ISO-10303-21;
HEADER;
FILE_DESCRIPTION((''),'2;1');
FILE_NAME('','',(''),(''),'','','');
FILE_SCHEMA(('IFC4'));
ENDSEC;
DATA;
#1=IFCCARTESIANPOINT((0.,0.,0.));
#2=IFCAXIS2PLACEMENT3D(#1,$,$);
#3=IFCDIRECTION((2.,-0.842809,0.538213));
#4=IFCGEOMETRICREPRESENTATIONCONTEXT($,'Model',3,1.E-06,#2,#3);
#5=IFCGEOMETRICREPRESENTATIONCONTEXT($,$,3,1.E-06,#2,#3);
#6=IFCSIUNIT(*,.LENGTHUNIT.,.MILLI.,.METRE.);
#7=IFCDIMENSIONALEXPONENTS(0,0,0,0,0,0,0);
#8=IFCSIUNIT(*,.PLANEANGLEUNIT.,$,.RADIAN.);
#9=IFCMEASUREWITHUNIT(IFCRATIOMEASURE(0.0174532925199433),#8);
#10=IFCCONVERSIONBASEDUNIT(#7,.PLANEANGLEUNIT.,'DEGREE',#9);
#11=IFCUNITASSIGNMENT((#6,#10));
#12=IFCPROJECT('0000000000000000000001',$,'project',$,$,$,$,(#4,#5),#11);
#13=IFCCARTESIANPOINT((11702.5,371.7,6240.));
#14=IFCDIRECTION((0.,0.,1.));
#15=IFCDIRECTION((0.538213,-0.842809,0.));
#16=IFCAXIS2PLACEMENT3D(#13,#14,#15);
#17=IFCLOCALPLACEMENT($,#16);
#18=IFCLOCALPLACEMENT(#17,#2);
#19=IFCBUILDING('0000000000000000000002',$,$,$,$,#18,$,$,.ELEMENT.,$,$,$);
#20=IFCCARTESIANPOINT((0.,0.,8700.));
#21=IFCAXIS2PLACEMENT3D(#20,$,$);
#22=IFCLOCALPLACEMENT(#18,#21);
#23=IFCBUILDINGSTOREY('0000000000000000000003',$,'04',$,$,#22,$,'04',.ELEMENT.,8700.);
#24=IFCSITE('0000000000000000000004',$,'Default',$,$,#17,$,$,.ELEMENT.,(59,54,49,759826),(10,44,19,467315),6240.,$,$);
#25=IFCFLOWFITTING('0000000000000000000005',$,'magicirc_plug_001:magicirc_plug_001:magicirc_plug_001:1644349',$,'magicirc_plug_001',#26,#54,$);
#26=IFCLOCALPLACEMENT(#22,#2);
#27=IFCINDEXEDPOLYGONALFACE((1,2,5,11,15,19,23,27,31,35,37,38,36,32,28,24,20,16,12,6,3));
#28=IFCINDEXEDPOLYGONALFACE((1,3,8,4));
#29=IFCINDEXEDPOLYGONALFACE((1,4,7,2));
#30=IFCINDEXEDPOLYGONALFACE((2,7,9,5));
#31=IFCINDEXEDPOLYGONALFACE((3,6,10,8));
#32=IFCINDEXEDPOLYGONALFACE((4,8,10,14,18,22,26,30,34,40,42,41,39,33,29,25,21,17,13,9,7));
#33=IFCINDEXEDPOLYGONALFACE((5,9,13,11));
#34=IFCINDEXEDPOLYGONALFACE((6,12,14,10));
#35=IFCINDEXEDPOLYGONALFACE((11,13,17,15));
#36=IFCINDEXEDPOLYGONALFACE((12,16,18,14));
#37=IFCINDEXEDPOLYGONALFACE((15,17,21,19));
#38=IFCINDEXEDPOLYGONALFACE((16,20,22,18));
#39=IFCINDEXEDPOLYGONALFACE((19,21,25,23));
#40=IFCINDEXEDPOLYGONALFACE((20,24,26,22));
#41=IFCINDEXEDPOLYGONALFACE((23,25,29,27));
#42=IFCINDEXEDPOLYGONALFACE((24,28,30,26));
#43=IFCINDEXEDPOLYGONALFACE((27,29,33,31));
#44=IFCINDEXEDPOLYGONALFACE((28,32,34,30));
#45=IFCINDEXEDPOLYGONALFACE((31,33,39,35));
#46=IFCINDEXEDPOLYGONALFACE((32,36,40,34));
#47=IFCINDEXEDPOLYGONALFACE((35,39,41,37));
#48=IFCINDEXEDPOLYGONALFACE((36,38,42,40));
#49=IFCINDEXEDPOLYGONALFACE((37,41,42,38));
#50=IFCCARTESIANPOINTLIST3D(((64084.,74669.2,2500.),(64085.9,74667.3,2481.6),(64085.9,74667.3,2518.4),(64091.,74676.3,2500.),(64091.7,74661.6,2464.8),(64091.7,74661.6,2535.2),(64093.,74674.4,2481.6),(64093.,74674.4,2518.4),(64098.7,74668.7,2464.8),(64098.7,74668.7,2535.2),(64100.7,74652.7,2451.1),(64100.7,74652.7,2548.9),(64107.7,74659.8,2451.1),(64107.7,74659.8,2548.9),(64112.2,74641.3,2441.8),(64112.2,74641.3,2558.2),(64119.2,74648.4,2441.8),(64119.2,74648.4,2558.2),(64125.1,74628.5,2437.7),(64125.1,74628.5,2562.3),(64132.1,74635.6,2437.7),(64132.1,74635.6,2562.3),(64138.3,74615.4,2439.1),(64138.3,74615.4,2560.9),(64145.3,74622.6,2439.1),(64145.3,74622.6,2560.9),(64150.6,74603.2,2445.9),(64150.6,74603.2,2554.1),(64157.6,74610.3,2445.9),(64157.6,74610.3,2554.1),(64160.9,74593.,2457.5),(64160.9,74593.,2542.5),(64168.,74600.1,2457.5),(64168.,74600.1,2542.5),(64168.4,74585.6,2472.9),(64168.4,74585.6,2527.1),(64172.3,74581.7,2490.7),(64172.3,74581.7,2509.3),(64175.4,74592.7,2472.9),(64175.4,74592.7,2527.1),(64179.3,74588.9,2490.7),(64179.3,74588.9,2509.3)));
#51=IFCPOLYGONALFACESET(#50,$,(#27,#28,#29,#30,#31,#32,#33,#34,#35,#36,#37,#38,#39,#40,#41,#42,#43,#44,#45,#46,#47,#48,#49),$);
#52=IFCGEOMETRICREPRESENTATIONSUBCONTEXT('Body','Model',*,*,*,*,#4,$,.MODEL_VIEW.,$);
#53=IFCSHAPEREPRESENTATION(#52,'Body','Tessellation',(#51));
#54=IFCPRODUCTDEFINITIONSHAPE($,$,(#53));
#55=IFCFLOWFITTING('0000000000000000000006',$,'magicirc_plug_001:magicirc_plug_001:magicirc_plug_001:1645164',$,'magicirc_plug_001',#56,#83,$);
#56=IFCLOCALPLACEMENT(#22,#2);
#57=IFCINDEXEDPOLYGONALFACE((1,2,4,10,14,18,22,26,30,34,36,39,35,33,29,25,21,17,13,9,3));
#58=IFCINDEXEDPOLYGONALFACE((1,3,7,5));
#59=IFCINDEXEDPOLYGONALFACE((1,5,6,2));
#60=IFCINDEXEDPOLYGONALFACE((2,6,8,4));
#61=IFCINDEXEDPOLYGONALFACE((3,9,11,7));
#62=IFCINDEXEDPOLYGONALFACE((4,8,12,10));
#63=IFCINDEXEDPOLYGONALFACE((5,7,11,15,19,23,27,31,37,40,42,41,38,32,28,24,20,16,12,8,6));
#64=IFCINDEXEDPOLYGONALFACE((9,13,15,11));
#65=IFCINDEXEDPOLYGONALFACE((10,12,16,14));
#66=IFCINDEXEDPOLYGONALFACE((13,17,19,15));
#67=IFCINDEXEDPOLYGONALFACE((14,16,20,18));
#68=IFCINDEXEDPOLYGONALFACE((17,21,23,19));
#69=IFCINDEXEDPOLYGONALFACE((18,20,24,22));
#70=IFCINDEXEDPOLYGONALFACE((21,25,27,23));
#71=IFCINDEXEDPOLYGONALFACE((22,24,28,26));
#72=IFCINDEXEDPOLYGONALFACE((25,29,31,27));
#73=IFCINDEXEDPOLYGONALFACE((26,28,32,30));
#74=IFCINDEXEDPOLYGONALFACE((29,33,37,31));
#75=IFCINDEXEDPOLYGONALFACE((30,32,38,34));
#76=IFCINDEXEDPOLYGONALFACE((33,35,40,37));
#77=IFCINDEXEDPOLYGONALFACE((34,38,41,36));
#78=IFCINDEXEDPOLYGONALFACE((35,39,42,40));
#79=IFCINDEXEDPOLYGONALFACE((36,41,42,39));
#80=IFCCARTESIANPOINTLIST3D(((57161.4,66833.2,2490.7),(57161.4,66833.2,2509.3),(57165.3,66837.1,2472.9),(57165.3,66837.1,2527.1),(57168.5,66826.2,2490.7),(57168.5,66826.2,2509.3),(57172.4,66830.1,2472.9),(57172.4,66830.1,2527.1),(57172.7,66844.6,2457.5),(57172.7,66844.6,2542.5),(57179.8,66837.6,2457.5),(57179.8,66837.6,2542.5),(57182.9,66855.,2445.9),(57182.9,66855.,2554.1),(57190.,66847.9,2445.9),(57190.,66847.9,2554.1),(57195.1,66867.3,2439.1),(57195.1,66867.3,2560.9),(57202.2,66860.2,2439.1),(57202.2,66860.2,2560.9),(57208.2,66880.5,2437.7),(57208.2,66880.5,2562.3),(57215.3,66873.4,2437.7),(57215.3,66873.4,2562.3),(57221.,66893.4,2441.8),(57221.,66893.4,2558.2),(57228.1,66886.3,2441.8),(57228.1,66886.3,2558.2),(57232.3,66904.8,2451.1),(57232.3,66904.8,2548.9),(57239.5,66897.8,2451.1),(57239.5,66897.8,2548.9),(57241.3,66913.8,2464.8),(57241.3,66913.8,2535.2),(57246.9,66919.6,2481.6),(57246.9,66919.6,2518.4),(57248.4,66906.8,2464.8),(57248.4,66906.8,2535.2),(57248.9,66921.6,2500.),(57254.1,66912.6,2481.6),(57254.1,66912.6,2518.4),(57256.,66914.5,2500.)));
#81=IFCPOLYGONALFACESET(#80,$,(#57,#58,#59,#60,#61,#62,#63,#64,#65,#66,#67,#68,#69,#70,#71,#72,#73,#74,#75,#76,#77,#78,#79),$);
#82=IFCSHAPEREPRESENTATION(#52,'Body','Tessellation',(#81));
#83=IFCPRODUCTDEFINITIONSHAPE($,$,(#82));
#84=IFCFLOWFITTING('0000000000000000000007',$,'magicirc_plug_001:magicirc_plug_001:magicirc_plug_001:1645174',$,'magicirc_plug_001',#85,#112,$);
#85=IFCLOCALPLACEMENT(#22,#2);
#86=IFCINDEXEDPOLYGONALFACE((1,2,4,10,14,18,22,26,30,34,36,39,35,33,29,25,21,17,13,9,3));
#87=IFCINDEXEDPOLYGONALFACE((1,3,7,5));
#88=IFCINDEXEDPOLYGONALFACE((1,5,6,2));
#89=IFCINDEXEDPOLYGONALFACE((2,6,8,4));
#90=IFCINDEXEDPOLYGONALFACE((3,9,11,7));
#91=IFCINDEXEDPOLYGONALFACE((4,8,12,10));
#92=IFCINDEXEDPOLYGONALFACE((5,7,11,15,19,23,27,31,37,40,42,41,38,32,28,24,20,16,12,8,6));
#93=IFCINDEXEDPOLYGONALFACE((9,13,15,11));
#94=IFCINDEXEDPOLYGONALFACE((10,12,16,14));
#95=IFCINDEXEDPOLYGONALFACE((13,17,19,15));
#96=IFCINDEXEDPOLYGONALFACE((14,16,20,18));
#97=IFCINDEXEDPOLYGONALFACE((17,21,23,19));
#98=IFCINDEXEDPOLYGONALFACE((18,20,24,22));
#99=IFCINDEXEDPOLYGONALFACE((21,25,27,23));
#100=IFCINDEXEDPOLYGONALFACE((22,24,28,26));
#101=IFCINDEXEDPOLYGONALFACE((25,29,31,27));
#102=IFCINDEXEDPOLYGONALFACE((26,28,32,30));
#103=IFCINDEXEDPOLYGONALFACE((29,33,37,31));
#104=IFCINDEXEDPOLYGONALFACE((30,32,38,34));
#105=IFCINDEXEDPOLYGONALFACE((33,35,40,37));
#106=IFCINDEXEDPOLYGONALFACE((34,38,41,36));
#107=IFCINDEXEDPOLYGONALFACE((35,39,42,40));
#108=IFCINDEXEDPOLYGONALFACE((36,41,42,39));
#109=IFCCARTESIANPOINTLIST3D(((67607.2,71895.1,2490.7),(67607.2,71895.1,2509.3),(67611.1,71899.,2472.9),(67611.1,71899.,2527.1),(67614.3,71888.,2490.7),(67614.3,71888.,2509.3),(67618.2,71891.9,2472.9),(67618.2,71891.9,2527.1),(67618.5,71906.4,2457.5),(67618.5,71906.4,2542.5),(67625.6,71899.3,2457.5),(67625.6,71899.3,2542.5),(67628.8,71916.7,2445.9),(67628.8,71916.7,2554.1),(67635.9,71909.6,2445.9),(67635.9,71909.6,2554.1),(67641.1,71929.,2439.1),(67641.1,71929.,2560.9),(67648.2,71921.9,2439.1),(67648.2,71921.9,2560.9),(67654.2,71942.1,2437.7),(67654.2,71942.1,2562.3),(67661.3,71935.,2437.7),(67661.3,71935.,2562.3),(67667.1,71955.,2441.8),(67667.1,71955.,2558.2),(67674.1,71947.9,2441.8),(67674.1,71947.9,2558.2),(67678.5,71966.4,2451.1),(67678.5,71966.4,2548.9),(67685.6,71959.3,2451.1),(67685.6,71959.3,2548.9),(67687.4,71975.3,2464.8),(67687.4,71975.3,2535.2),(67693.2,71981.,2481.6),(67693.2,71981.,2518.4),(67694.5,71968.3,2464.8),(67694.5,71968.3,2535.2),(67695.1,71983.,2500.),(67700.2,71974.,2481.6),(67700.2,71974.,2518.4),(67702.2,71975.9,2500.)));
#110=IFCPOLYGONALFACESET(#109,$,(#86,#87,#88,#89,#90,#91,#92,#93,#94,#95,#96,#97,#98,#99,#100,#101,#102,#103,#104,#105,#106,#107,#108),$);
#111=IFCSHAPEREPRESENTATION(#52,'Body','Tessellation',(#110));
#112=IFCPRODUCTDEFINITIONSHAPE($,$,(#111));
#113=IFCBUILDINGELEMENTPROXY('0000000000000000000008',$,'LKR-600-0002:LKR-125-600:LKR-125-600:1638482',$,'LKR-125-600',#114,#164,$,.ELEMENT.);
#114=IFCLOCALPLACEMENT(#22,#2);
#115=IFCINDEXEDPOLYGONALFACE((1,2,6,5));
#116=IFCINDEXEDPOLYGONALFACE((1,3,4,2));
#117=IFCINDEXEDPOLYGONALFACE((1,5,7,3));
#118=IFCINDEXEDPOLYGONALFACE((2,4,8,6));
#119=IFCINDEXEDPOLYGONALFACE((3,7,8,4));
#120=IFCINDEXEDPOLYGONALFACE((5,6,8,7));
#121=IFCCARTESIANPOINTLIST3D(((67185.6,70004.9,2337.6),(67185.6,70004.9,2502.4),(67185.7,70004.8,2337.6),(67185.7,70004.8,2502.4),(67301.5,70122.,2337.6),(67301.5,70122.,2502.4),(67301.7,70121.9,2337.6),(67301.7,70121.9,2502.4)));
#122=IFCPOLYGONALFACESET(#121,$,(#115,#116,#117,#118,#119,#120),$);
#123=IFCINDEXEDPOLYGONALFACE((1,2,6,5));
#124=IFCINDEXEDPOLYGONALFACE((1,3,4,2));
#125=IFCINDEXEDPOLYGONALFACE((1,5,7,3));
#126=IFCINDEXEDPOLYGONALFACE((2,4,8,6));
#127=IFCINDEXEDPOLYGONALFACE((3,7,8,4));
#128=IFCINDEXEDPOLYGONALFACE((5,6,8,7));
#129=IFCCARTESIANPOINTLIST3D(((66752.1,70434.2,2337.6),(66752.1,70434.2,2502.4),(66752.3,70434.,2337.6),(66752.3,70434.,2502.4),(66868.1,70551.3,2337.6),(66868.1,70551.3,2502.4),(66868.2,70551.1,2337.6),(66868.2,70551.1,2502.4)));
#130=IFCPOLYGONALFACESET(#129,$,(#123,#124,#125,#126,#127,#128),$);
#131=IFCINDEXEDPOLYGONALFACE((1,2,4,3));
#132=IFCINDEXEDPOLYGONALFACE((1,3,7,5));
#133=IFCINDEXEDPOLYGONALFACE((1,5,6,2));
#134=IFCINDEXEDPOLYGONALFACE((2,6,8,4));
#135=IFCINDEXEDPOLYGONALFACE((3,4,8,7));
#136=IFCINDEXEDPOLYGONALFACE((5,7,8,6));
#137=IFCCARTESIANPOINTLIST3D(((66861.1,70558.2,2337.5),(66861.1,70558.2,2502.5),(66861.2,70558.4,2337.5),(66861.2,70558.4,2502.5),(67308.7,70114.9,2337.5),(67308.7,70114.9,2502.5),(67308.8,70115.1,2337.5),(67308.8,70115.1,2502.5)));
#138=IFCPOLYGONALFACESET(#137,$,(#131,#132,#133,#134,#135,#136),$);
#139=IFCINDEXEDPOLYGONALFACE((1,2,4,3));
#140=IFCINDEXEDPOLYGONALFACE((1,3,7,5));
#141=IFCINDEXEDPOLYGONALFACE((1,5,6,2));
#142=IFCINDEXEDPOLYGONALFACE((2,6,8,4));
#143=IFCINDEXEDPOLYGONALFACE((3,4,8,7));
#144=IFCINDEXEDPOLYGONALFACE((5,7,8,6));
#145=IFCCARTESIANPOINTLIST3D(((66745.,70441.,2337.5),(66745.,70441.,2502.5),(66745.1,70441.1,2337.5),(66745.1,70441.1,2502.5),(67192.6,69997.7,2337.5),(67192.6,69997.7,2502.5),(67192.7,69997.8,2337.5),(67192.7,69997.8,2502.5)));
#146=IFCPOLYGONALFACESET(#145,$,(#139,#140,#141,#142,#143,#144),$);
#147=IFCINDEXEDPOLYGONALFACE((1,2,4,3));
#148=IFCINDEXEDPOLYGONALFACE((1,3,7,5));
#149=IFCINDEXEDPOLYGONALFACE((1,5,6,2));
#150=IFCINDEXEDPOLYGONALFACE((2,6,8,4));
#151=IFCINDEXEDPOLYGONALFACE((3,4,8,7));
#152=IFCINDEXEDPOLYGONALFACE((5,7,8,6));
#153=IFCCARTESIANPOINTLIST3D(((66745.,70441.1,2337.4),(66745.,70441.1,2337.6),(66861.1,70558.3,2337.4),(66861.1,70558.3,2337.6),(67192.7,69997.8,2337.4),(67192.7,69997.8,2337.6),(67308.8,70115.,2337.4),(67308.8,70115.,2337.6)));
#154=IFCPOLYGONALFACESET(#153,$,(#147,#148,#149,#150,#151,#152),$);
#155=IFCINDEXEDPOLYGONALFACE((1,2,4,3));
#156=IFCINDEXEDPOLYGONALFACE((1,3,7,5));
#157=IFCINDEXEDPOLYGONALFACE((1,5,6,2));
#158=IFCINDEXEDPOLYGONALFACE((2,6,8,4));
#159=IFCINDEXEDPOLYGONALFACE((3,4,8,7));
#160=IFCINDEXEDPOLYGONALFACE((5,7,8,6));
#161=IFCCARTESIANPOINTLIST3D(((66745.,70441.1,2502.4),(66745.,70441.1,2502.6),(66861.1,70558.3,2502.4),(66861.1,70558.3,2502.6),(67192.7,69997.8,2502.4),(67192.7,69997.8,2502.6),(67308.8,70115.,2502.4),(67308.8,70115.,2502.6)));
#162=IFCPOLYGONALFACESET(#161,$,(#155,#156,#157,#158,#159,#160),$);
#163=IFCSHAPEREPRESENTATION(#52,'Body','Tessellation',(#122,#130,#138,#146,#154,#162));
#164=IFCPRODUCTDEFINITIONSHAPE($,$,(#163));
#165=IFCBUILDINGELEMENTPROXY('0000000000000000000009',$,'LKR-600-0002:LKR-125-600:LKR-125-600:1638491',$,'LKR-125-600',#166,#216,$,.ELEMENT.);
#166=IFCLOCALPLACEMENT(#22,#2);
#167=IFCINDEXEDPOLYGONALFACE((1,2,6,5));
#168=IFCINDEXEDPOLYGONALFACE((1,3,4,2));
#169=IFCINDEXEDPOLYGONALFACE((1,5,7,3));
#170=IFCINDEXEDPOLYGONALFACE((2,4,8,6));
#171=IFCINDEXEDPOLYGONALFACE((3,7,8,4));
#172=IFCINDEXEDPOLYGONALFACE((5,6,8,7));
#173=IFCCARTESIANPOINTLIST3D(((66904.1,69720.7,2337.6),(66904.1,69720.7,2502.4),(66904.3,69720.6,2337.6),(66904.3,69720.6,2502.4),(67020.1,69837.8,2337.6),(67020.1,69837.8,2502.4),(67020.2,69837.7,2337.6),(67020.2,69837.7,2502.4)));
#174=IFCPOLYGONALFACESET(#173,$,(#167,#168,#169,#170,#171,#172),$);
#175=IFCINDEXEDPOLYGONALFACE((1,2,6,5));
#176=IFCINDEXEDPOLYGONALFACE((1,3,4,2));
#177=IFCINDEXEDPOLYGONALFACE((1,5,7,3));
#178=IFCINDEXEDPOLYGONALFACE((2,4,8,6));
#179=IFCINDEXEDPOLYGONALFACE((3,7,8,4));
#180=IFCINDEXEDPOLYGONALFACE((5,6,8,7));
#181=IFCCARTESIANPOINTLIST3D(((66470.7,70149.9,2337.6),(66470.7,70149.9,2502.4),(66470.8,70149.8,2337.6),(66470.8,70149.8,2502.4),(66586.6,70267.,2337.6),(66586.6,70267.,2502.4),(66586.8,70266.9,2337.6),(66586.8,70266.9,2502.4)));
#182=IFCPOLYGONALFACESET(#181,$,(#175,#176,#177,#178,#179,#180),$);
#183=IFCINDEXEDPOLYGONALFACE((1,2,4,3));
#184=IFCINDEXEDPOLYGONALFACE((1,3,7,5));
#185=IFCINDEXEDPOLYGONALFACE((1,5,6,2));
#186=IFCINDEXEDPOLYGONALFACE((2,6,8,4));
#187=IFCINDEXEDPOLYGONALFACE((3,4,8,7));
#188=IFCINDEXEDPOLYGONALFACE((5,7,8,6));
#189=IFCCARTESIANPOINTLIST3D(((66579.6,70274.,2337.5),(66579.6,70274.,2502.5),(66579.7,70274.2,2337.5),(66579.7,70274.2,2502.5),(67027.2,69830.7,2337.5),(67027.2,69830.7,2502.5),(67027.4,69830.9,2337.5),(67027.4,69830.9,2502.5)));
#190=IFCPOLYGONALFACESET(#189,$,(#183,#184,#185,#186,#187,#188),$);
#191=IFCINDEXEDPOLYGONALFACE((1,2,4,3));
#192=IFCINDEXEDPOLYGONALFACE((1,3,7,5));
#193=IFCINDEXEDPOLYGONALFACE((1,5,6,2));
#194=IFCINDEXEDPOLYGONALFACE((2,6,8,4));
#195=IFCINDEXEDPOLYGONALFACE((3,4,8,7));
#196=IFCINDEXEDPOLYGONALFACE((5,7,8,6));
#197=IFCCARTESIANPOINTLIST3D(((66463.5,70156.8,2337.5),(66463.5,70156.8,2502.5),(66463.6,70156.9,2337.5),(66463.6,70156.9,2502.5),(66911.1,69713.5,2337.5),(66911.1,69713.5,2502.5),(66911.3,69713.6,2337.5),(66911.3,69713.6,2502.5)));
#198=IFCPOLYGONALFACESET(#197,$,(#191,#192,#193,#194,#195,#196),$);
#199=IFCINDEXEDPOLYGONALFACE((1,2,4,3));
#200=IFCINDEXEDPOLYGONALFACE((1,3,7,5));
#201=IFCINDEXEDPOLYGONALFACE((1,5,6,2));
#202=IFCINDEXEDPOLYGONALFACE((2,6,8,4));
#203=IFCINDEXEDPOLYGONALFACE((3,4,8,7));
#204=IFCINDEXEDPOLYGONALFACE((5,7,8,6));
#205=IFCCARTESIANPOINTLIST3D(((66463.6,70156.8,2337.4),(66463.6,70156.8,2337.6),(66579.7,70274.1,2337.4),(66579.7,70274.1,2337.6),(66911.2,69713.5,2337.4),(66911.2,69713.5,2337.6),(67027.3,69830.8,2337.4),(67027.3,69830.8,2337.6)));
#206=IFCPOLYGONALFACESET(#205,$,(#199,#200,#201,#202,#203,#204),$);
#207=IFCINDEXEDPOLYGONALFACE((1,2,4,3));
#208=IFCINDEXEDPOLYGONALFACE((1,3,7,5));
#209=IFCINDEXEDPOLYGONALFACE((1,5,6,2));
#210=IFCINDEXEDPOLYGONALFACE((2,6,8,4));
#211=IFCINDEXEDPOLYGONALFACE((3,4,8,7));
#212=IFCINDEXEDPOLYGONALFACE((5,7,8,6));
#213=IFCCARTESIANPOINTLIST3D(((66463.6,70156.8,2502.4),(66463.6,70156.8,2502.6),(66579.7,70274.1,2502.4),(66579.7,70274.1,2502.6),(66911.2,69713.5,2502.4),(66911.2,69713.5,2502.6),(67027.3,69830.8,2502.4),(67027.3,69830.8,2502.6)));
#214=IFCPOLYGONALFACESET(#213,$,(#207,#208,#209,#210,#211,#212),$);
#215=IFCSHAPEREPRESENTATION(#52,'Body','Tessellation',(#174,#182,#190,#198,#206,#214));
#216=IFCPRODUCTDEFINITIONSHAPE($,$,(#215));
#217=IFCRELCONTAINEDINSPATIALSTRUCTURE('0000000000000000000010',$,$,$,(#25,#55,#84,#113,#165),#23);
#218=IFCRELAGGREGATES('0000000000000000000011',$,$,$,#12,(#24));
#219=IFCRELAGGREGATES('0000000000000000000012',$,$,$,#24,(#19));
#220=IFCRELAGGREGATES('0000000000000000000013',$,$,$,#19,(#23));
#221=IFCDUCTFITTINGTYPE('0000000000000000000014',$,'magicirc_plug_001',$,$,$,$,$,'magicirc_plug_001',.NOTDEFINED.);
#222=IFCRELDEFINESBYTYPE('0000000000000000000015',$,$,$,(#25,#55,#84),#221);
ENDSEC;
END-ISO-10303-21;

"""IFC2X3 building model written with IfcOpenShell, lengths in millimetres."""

from ifc_helpers import new_model, entity, si_unit, converted_unit, direction, frame, frame_2d, origin, place, context, subcontext, project, spatial, rectangle, circle, extrude, source, transform, mapped, type_object, type_shapes, element, save


model = new_model("IFC2X3")

# Units and contexts
model_context = context("Model", 3, precision=1e-06, world=origin(), true_north=direction((2.0, -0.842809, 0.538213)))
context_of_model = context(None, 3, precision=1e-06, world=origin(), true_north=direction((2.0, -0.842809, 0.538213)))
body_context = subcontext(model_context, "Body", "Model", "MODEL_VIEW")
ifc_project = project(units=[si_unit("LENGTHUNIT", "METRE", prefix="MILLI"), converted_unit("PLANEANGLEUNIT", "DEGREE", entity("IfcRatioMeasure", 0.0174532925199433), si_unit("PLANEANGLEUNIT", "RADIAN"), dimensions=[0, 0, 0, 0, 0, 0, 0])], contexts=[model_context, context_of_model])

# Site, building, storey
site_placement = place(None, frame((11702.5, 371.7, 6240.0), z_axis=(0.0, 0.0, 1.0), x_axis=(0.538213, -0.842809, 0.0)))
site = spatial("IfcSite", under=ifc_project, at=site_placement, Name="Default", CompositionType="ELEMENT", RefLatitude=(59, 54, 49, 759826), RefLongitude=(10, 44, 19, 467315), RefElevation=6240.0)
building_placement = place(site_placement, origin())
building = spatial("IfcBuilding", under=site, at=building_placement, CompositionType="ELEMENT")
storey_placement = place(building_placement, frame((0.0, 0.0, 8700.0)))
storey = spatial("IfcBuildingStorey", under=building, at=storey_placement, Name="04", LongName="04", CompositionType="ELEMENT", Elevation=8700.0)

# Flow fittings
duct_fitting_type_1 = type_object("IfcDuctFittingType", Name="magicirc_plug_001", ElementType="magicirc_plug_001", PredefinedType="NOTDEFINED")
shared_shape_1 = source(origin(), body_context, "Body", "SweptSolid", [
    extrude(circle(Radius=62.5, at=frame_2d((0.0, 0.0), x_axis=(1.0, 0.0))), frame((0.0, 0.0, 0.0), z_axis=(1.0, 0.0, 0.0), x_axis=(0.0, 1.0, 0.0)), (0.0, 0.0, 1.0), 10.0),
])
type_shapes(duct_fitting_type_1, [shared_shape_1])
for number, where, z_axis, x_axis, name in (
    (1, (64128.4, 74625.2, 2500.0), (0.0, 0.0, 1.0), (0.703643, 0.710554, 0.0), "magicirc_plug_001:magicirc_plug_001:magicirc_plug_001:1644349"),
    (2, (57204.9, 66877.2, 2500.0), (0.0, 0.0, 1.0), (0.710554, -0.703643, 0.0), "magicirc_plug_001:magicirc_plug_001:magicirc_plug_001:1645164"),
    (3, (67650.9, 71938.8, 2500.0), (0.0, 0.0, 1.0), (0.707107, -0.707107, 0.0), "magicirc_plug_001:magicirc_plug_001:magicirc_plug_001:1645174"),
):
    element("IfcFlowFitting", number, at=place(storey_placement, frame(where, z_axis=z_axis, x_axis=x_axis)), inside=storey, type_object=duct_fitting_type_1, Name=name, ObjectType="magicirc_plug_001", context=body_context, shape_type="MappedRepresentation", body=[
        mapped(shared_shape_1, transform((0.0, 0.0, 0.0), scale=1.0)),
    ])

# Building element proxies
shared_shape_2 = source(origin(), body_context, "Body", "SweptSolid", [
    extrude(rectangle(XDim=0.2, YDim=164.8, at=frame_2d((0.0, 0.0), x_axis=(1.0, 0.0))), frame((305.0, 0.0, -82.4)), (0.0, 0.0, 1.0), 164.8),
    extrude(rectangle(XDim=0.2, YDim=164.8, at=frame_2d((0.0, 0.0), x_axis=(1.0, 0.0))), frame((-305.0, 0.0, -82.4)), (0.0, 0.0, 1.0), 164.8),
    extrude(rectangle(XDim=0.2, YDim=630.0, at=frame_2d((0.0, 0.0), x_axis=(1.0, 0.0))), frame((0.0, 82.5, -82.5), z_axis=(0.0, 0.0, 1.0), x_axis=(0.0, 1.0, 0.0)), (0.0, 0.0, 1.0), 165.0),
    extrude(rectangle(XDim=0.2, YDim=630.0, at=frame_2d((0.0, 0.0), x_axis=(1.0, 0.0))), frame((0.0, -82.5, -82.5), z_axis=(0.0, 0.0, 1.0), x_axis=(0.0, 1.0, 0.0)), (0.0, 0.0, 1.0), 165.0),
    extrude(rectangle(XDim=165.0, YDim=630.0, at=frame_2d((0.0, 0.0), x_axis=(1.0, 0.0))), frame((0.0, 0.0, -82.6), z_axis=(0.0, 0.0, 1.0), x_axis=(0.0, -1.0, 0.0)), (0.0, 0.0, 1.0), 0.2),
    extrude(rectangle(XDim=165.0, YDim=630.0, at=frame_2d((0.0, 0.0), x_axis=(1.0, 0.0))), frame((0.0, 0.0, 82.4), z_axis=(0.0, 0.0, 1.0), x_axis=(0.0, -1.0, 0.0)), (0.0, 0.0, 1.0), 0.2),
])
for number, where, z_axis, x_axis, name in (
    (4, (67026.9, 70278.0, 2420.0), (0.0, 0.0, 1.0), (0.710554, -0.703643, 0.0), "LKR-600-0002:LKR-125-600:LKR-125-600:1638482"),
    (5, (66745.4, 69993.8, 2420.0), (0.0, 0.0, 1.0), (0.710554, -0.703643, 0.0), "LKR-600-0002:LKR-125-600:LKR-125-600:1638491"),
):
    element("IfcBuildingElementProxy", number, at=place(storey_placement, frame(where, z_axis=z_axis, x_axis=x_axis)), inside=storey, Name=name, ObjectType="LKR-125-600", CompositionType="ELEMENT", context=body_context, shape_type="MappedRepresentation", body=[
        mapped(shared_shape_2, transform((0.0, 0.0, 0.0), scale=1.0)),
    ])

save(model, "model.ifc")
